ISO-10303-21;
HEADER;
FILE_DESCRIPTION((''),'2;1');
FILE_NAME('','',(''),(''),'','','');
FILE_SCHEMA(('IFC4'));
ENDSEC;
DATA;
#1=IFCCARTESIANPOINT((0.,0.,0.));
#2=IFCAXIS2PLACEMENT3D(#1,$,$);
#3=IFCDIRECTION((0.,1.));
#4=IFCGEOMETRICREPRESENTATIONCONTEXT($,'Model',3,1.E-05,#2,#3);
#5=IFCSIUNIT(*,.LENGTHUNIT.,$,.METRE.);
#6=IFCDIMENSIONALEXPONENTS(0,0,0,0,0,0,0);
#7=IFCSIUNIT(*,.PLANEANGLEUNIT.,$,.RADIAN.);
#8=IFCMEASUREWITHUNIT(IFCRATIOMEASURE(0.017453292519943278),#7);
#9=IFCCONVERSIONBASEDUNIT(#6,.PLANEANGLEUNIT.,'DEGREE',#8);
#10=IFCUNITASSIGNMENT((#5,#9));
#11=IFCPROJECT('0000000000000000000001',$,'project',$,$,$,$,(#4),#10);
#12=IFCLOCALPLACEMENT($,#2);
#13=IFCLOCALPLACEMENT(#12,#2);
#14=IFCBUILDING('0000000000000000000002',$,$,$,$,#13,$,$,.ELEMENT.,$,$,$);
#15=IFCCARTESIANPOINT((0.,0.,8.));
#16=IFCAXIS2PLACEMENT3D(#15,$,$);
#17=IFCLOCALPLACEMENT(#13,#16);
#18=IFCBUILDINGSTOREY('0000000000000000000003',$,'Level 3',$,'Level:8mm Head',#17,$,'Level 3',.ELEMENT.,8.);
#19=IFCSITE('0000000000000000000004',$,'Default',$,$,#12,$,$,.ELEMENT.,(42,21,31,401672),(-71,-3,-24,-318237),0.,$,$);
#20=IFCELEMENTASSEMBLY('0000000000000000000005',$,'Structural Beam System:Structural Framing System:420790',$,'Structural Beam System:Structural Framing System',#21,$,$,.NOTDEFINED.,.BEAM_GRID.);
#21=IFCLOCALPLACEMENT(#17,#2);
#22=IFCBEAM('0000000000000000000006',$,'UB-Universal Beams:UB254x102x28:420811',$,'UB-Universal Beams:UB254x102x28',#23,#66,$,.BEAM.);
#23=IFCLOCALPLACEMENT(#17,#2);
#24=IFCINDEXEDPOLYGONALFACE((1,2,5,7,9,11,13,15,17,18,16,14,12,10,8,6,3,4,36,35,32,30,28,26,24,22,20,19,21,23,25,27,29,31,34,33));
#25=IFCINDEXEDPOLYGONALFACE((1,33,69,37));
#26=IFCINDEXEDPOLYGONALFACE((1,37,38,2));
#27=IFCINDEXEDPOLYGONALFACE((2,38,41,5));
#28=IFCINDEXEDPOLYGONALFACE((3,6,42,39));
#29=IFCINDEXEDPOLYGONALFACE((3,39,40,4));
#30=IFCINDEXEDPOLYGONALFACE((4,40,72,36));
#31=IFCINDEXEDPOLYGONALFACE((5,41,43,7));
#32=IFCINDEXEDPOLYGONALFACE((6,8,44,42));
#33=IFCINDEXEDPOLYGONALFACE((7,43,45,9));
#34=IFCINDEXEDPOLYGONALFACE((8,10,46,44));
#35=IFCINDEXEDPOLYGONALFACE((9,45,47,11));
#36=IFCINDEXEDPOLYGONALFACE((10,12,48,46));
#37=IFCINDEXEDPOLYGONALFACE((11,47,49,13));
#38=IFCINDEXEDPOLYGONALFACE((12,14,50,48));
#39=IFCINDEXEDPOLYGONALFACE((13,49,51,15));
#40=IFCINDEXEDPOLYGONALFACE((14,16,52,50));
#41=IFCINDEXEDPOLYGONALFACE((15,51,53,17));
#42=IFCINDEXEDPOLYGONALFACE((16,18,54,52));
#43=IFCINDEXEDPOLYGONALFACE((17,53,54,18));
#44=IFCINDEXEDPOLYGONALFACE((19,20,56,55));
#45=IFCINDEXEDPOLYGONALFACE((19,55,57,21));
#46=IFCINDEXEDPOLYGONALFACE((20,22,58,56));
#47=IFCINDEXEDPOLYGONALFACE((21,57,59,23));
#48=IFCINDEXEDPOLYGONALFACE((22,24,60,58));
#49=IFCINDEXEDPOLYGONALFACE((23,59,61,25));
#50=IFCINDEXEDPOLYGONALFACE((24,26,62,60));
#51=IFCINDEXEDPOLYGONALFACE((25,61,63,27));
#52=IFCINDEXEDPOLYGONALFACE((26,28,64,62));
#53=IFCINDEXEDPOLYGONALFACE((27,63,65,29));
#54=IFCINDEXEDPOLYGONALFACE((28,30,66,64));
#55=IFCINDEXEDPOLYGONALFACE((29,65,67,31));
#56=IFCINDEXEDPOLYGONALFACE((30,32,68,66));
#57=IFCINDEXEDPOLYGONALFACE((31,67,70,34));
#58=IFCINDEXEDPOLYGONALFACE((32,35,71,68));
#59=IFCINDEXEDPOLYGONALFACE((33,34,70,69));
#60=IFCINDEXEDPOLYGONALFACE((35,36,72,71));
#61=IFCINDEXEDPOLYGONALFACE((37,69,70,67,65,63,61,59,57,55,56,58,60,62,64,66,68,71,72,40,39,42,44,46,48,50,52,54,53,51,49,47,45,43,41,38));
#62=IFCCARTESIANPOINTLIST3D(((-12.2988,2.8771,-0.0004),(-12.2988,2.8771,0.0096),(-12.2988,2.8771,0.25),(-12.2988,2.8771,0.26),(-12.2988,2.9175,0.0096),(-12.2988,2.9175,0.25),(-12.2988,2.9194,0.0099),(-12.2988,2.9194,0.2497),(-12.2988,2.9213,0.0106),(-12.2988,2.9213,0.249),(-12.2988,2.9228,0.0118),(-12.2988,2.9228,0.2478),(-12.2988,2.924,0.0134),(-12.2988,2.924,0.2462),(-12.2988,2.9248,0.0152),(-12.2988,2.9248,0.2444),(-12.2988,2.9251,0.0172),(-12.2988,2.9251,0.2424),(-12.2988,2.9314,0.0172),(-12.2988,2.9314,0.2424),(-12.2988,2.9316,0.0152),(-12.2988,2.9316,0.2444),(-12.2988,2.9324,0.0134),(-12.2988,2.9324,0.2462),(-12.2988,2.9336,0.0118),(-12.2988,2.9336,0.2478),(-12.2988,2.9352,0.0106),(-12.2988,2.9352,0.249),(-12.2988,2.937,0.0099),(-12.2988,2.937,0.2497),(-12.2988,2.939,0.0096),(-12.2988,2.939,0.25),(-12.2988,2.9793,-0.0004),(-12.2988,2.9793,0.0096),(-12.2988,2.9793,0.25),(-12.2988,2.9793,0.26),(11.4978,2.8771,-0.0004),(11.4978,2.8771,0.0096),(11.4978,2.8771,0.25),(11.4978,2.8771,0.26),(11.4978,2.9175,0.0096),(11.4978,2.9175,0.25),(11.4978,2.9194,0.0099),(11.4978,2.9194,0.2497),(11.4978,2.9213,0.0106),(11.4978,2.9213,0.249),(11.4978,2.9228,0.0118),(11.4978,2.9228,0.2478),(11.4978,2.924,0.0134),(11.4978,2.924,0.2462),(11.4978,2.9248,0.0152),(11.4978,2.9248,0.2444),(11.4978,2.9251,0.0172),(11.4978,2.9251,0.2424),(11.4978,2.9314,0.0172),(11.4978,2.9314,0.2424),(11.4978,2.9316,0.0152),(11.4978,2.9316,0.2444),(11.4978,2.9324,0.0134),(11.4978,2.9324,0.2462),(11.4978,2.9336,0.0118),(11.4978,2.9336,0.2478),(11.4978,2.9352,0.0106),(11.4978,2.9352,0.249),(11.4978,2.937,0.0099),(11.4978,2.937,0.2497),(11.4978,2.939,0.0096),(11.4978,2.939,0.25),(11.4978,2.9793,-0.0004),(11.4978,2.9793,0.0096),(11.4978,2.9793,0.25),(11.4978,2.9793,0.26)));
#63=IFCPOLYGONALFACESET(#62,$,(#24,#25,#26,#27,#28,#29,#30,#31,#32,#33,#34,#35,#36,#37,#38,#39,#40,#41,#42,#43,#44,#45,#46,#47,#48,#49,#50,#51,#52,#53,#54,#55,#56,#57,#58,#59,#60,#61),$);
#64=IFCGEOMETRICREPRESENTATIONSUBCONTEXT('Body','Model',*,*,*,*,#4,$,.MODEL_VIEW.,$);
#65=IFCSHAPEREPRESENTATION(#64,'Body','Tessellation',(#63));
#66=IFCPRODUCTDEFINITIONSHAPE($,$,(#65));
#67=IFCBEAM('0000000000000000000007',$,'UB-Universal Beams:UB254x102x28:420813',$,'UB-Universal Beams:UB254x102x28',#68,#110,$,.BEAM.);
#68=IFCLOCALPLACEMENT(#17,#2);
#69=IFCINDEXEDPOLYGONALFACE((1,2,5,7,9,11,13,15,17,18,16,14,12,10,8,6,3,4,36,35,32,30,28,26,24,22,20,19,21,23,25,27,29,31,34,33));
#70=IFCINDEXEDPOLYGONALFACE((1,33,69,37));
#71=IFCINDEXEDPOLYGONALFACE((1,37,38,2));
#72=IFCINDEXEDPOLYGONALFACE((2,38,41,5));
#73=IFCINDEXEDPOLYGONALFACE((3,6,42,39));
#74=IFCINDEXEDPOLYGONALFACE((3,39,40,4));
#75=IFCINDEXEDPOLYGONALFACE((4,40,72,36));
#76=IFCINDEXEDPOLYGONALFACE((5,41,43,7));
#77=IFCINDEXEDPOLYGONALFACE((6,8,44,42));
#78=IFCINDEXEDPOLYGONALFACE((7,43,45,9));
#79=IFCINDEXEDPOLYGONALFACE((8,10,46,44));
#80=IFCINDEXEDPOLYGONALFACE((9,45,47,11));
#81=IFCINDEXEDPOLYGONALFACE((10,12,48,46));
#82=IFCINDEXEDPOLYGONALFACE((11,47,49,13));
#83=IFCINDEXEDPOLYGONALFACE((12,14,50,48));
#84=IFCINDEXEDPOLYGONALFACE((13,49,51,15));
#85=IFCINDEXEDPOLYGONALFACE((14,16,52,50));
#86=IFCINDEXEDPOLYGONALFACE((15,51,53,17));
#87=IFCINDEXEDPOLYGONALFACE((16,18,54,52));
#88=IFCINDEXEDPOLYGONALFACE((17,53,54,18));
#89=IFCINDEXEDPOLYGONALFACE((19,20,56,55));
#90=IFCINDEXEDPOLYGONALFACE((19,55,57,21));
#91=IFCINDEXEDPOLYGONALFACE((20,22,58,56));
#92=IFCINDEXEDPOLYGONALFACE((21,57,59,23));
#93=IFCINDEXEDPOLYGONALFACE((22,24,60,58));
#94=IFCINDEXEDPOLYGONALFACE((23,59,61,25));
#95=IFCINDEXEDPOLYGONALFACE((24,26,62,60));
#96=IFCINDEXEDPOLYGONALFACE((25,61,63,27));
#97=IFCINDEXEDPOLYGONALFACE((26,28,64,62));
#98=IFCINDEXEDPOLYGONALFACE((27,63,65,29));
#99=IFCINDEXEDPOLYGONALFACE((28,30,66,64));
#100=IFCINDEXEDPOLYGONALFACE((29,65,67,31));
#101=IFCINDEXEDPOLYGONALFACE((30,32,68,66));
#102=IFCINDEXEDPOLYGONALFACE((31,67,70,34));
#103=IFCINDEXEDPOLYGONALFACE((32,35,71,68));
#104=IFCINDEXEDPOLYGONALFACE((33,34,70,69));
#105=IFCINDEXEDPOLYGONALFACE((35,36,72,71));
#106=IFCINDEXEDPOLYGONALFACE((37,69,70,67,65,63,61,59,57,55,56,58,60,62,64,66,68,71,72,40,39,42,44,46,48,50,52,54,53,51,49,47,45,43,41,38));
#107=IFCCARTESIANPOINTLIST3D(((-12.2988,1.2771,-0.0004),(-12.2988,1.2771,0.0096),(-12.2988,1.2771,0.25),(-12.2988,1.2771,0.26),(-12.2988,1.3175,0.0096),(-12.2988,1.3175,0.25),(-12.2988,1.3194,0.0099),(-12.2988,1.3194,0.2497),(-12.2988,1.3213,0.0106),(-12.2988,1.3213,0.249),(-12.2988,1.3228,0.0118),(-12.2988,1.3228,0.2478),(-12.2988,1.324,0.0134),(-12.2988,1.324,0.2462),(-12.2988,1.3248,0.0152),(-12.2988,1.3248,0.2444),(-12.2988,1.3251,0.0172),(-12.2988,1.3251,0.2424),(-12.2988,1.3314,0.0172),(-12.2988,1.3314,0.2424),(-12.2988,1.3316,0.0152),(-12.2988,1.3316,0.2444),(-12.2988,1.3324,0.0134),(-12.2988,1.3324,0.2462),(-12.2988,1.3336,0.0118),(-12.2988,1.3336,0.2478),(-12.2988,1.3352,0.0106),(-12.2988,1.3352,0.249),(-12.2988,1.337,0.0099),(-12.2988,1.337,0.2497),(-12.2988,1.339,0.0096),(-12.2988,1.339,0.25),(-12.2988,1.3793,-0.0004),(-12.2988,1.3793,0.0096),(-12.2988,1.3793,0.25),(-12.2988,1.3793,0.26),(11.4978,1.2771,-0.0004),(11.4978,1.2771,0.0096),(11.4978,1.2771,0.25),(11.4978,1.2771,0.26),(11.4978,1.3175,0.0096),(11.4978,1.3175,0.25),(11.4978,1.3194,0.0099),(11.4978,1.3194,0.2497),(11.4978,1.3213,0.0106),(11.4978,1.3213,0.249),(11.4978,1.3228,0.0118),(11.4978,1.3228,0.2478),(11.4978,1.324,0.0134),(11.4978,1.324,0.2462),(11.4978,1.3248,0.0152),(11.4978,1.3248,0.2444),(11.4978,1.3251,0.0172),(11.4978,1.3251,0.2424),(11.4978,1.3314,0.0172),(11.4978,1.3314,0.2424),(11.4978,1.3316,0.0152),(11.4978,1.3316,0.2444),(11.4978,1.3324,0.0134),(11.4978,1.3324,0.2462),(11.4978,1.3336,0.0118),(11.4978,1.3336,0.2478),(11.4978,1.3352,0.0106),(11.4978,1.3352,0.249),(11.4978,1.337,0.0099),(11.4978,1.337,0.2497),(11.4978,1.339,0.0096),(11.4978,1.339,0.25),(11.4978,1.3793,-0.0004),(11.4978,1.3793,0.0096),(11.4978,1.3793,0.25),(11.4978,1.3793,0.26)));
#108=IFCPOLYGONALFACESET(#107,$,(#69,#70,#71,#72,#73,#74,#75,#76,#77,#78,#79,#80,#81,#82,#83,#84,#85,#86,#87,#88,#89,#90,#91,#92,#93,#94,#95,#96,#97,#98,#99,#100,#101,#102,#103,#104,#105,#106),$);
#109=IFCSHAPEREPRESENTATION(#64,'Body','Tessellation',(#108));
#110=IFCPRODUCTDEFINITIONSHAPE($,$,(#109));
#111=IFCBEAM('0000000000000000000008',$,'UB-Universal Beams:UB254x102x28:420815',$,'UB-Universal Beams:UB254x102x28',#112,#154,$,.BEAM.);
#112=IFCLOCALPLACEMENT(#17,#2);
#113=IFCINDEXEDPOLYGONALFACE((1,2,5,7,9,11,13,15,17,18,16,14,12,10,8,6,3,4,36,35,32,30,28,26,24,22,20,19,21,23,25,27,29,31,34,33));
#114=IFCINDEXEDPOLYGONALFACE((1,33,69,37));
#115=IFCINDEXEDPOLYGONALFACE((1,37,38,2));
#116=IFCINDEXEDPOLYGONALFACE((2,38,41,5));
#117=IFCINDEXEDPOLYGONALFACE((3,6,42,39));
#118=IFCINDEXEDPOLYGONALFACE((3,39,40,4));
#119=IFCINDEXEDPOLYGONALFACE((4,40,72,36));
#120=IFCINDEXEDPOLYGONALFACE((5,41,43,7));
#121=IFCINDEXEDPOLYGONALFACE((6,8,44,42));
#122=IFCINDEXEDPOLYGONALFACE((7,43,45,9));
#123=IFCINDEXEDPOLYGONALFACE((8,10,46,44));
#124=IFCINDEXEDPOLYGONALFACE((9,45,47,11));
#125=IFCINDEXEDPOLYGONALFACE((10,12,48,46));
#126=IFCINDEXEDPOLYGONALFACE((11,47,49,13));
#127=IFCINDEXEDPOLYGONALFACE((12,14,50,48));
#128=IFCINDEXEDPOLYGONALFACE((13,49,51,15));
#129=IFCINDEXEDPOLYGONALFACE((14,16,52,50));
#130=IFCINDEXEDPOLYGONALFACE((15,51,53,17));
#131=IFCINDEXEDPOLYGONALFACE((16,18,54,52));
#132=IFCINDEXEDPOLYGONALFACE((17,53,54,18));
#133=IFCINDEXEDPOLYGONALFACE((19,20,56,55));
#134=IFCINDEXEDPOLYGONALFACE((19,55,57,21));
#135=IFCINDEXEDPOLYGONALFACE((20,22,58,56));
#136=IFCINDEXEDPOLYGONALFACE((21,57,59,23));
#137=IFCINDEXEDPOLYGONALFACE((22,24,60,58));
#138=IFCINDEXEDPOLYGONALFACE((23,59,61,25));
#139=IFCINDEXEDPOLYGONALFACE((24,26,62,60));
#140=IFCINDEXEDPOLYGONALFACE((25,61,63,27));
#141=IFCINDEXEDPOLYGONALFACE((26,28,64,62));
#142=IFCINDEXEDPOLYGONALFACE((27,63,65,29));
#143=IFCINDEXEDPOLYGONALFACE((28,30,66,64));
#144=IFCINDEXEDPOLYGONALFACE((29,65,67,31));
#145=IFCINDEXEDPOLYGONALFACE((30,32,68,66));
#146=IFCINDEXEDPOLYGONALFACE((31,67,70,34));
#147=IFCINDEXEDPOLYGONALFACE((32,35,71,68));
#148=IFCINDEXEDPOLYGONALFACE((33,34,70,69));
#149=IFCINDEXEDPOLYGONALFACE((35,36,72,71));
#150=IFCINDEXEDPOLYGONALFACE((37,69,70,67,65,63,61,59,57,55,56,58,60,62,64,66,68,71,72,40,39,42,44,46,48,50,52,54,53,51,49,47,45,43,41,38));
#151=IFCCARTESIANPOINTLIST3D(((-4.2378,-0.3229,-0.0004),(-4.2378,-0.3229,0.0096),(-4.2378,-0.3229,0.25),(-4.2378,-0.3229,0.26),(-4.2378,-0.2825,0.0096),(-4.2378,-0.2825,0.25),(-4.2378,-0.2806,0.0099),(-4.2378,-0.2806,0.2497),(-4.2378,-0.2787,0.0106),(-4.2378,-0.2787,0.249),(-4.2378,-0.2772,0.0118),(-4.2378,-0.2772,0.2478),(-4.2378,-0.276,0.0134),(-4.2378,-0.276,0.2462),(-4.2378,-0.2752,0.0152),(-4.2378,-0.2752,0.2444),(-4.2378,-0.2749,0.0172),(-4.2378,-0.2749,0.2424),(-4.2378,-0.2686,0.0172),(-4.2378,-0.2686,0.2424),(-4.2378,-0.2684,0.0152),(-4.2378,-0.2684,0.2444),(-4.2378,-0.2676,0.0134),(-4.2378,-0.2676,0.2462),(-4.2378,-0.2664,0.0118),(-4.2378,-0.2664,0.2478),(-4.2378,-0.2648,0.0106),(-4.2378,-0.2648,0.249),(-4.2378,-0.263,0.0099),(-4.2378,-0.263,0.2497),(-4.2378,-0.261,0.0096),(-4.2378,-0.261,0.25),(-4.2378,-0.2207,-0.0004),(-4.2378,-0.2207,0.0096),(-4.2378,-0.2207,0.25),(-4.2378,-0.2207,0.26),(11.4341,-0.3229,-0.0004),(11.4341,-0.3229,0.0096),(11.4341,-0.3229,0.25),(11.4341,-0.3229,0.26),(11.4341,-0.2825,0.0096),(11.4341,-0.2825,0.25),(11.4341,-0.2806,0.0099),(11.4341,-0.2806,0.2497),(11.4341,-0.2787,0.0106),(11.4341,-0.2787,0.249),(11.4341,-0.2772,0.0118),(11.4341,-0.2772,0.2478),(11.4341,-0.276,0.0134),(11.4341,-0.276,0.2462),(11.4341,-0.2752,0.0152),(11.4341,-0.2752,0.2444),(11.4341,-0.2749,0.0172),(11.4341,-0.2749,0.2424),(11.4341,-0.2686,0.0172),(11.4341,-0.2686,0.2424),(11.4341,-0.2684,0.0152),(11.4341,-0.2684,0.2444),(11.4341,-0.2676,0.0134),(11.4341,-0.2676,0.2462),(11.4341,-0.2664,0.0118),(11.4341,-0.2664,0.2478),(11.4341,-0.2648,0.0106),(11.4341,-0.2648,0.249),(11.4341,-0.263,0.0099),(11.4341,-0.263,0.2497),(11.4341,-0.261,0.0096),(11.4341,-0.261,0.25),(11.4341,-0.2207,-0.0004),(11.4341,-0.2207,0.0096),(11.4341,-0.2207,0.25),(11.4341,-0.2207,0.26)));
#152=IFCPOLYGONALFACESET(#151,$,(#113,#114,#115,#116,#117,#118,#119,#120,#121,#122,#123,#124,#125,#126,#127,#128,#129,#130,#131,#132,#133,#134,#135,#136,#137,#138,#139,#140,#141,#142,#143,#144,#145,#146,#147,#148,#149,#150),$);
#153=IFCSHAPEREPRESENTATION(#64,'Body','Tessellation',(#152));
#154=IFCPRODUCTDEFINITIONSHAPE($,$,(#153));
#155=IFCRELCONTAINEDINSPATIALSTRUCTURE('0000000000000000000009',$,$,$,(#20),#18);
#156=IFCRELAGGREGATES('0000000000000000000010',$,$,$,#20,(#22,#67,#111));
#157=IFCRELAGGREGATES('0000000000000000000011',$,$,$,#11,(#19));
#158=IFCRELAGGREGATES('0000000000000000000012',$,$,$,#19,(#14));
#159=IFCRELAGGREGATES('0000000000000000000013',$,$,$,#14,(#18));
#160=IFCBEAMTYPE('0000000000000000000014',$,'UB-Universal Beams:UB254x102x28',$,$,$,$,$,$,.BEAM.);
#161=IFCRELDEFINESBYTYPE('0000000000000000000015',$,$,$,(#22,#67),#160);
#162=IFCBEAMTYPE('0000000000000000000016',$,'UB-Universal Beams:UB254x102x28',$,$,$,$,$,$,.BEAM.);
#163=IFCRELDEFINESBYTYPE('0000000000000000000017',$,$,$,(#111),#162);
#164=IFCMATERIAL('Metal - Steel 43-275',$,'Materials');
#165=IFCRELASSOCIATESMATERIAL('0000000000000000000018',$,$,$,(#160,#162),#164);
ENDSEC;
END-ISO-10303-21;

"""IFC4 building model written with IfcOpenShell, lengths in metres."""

from ifc_helpers import new_model, entity, si_unit, converted_unit, direction, frame, frame_2d, origin, place, context, subcontext, project, spatial, i_section, extrude, source, transform, mapped, material, material_profile, profile_set, type_object, type_shapes, element, aggregate, save


model = new_model("IFC4")

# Units and contexts
model_context = context("Model", 3, precision=1e-05, world=origin(), true_north=direction((0.0, 1.0)))
body_context = subcontext(model_context, "Body", "Model", "MODEL_VIEW")
ifc_project = project(units=[si_unit("LENGTHUNIT", "METRE"), converted_unit("PLANEANGLEUNIT", "DEGREE", entity("IfcRatioMeasure", 0.017453292519943278), si_unit("PLANEANGLEUNIT", "RADIAN"), dimensions=[0, 0, 0, 0, 0, 0, 0])], contexts=[model_context])

# Site, building, storey
site_placement = place(None, origin())
site = spatial("IfcSite", under=ifc_project, at=site_placement, Name="Default", CompositionType="ELEMENT", RefLatitude=(42, 21, 31, 401672), RefLongitude=(-71, -3, -24, -318237), RefElevation=0.0)
building_placement = place(site_placement, origin())
building = spatial("IfcBuilding", under=site, at=building_placement, CompositionType="ELEMENT")
storey_placement = place(building_placement, frame((0.0, 0.0, 8.0)))
storey = spatial("IfcBuildingStorey", under=building, at=storey_placement, Name="Level 3", ObjectType="Level:8mm Head", LongName="Level 3", CompositionType="ELEMENT", Elevation=8.0)

# Shared definitions
ifc_material_1 = material(Name="Metal - Steel 43-275", Category="Materials")

# Element assembly, beams
assembly_placement = place(storey_placement, origin())
assembly = element("IfcElementAssembly", 1, at=assembly_placement, inside=storey, Name="Structural Beam System:Structural Framing System:420790", ObjectType="Structural Beam System:Structural Framing System", AssemblyPlace="NOTDEFINED", PredefinedType="BEAM_GRID")
ifc_material_profile_1 = material_profile(ifc_material_1, i_section(OverallWidth=0.1022, OverallDepth=0.2604, WebThickness=0.0063, FlangeThickness=0.01, FilletRadius=0.0076, at=frame_2d((0.0, 0.0), x_axis=(0.0, 1.0))), Name="UB254x102x28")
ifc_profile_set_1 = profile_set([ifc_material_profile_1], Name="UB254x102x28")
beam_type_1 = type_object("IfcBeamType", Name="UB-Universal Beams:UB254x102x28", PredefinedType="BEAM", material=ifc_profile_set_1)
shared_shape_1 = source(origin(), body_context, "Body", "SweptSolid", [
    extrude(i_section(OverallWidth=0.1022, OverallDepth=0.2604, WebThickness=0.0063, FlangeThickness=0.01, FilletRadius=0.0076, at=frame_2d((0.0, 0.0), x_axis=(0.0, 1.0))), frame((-11.8983, 0.0, 0.0), z_axis=(1.0, 0.0, 0.0), x_axis=(0.0, 0.0, -1.0)), (0.0, 0.0, 1.0), 23.7966),
])
type_shapes(beam_type_1, [shared_shape_1])
beam_1_placement = place(assembly_placement, frame((-0.4005, 2.9282, 0.1298)))
beam_1 = element("IfcBeam", 2, at=beam_1_placement, type_object=beam_type_1, Name="UB-Universal Beams:UB254x102x28:420811", ObjectType="UB-Universal Beams:UB254x102x28", PredefinedType="BEAM", context=body_context, shape_type="MappedRepresentation", body=[
    mapped(shared_shape_1, transform((0.0, 0.0, 0.0), scale=1.0)),
])
beam_2_placement = place(assembly_placement, frame((-0.4005, 1.3282, 0.1298)))
beam_2 = element("IfcBeam", 3, at=beam_2_placement, type_object=beam_type_1, Name="UB-Universal Beams:UB254x102x28:420813", ObjectType="UB-Universal Beams:UB254x102x28", PredefinedType="BEAM", context=body_context, shape_type="MappedRepresentation", body=[
    mapped(shared_shape_1, transform((0.0, 0.0, 0.0), scale=1.0)),
])
beam_type_2 = type_object("IfcBeamType", Name="UB-Universal Beams:UB254x102x28", PredefinedType="BEAM", material=ifc_profile_set_1)
shared_shape_2 = source(origin(), body_context, "Body", "SweptSolid", [
    extrude(i_section(OverallWidth=0.1022, OverallDepth=0.2604, WebThickness=0.0063, FlangeThickness=0.01, FilletRadius=0.0076, at=frame_2d((0.0, 0.0), x_axis=(0.0, 1.0))), frame((-7.8818, 0.0, 0.0), z_axis=(1.0, 0.0, 0.0), x_axis=(0.0, 0.0, -1.0)), (0.0, 0.0, 1.0), 15.6719),
])
type_shapes(beam_type_2, [shared_shape_2])
beam_3_placement = place(assembly_placement, frame((3.644, -0.2718, 0.1298)))
beam_3 = element("IfcBeam", 4, at=beam_3_placement, type_object=beam_type_2, Name="UB-Universal Beams:UB254x102x28:420815", ObjectType="UB-Universal Beams:UB254x102x28", PredefinedType="BEAM", context=body_context, shape_type="MappedRepresentation", body=[
    mapped(shared_shape_2, transform((0.0, 0.0, 0.0), scale=1.0)),
])
aggregate(assembly, [beam_1, beam_2, beam_3])

save(model, "model.ifc")
